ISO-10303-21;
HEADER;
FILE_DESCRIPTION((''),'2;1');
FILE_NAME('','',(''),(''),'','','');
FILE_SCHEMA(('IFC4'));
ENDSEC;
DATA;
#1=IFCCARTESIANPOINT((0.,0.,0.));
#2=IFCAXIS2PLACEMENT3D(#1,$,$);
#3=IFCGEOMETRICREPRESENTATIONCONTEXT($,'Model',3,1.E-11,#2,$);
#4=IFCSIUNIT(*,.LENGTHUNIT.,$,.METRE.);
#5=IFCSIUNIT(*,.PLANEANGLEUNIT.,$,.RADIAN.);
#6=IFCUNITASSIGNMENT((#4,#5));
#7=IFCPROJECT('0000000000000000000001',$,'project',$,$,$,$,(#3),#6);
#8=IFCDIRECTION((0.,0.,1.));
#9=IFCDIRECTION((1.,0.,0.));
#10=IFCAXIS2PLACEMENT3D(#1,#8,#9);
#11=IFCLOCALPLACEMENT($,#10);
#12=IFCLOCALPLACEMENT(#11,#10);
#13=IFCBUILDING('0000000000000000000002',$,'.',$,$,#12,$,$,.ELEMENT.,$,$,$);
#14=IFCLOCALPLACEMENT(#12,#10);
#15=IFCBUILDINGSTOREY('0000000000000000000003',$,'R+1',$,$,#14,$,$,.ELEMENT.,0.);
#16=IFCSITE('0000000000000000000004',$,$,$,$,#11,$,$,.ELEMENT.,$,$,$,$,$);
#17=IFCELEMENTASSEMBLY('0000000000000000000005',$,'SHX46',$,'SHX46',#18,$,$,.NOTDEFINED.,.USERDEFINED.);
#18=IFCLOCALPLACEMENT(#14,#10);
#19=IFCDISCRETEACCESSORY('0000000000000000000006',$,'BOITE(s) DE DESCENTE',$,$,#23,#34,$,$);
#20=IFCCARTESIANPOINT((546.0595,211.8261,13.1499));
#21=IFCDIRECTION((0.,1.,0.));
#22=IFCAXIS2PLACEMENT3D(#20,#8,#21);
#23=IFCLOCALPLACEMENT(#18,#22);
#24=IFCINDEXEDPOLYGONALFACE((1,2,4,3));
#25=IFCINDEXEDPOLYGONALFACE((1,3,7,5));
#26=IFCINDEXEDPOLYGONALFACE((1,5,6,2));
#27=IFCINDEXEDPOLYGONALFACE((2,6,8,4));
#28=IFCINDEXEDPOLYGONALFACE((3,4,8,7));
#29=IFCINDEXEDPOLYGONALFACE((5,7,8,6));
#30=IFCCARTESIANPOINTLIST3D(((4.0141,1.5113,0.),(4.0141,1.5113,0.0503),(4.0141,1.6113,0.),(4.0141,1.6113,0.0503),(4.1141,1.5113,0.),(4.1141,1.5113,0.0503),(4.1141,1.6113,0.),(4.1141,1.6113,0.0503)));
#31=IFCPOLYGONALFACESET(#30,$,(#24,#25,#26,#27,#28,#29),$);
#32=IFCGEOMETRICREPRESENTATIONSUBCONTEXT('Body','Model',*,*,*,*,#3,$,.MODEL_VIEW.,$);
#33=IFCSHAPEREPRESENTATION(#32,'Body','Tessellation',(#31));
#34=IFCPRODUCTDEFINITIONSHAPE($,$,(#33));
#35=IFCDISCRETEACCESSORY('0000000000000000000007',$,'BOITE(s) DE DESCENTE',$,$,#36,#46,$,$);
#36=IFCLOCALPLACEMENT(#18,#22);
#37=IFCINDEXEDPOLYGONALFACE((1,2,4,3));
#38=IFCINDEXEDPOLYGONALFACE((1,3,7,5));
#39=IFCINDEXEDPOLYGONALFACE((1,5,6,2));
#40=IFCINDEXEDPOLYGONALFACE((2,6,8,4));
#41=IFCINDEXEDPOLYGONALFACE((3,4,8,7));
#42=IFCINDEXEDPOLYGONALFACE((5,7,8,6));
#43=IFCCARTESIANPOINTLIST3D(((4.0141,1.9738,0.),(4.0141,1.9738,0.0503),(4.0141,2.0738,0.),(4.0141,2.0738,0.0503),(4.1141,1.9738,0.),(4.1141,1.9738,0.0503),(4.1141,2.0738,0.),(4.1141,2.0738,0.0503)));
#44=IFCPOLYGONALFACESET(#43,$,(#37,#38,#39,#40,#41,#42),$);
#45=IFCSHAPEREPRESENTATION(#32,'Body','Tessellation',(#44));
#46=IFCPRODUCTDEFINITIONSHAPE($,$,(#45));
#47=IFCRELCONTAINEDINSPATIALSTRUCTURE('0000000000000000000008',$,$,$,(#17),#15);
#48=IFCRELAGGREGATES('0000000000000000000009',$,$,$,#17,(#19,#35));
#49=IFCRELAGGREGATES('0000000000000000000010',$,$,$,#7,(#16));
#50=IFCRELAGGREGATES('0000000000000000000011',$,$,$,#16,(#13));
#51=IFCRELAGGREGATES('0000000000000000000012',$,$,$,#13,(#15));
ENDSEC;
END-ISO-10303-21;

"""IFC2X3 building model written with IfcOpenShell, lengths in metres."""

from ifc_helpers import new_model, si_unit, frame, origin, origin_with_axes, place, context, subcontext, project, spatial, polyline, outline, extrude, element, aggregate, save


model = new_model("IFC2X3")

# Units and contexts
model_context = context("Model", 3, precision=1e-11, world=origin())
body_context = subcontext(model_context, "Body", "Model", "MODEL_VIEW")
ifc_project = project(units=[si_unit("LENGTHUNIT", "METRE"), si_unit("PLANEANGLEUNIT", "RADIAN")], contexts=[model_context])

# Site, building, storey
site_placement = place(None, origin_with_axes())
site = spatial("IfcSite", under=ifc_project, at=site_placement, CompositionType="ELEMENT")
building_placement = place(site_placement, origin_with_axes())
building = spatial("IfcBuilding", under=site, at=building_placement, Name=".", CompositionType="ELEMENT")
storey_placement = place(building_placement, origin_with_axes())
storey = spatial("IfcBuildingStorey", under=building, at=storey_placement, Name="R+1", CompositionType="ELEMENT", Elevation=0.0)

# Element assembly, discrete accessories
assembly_1_placement = place(storey_placement, origin_with_axes())
assembly_1 = element("IfcElementAssembly", 1, at=assembly_1_placement, inside=storey, Name="SHX46", ObjectType="SHX46", AssemblyPlace="NOTDEFINED", PredefinedType="USERDEFINED")
discrete_accessory_1_placement = place(assembly_1_placement, frame((546.0595, 211.8261, 13.1499), z_axis=(0.0, 0.0, 1.0), x_axis=(0.0, 1.0, 0.0)))
discrete_accessory_1 = element("IfcDiscreteAccessory", 2, at=discrete_accessory_1_placement, Name="BOITE(s) DE DESCENTE", context=body_context, shape_type="SweptSolid", body=[
    extrude(outline(polyline([(1.5113, -4.0141), (1.5113, -4.1141), (1.6113, -4.1141), (1.6113, -4.0141), (1.5113, -4.0141)])), frame((0.0, 0.0, 0.0), z_axis=(0.0, 0.0, 1.0), x_axis=(0.0, 1.0, 0.0)), (0.0, 0.0, 1.0), 0.0503),
])
discrete_accessory_2_placement = place(assembly_1_placement, frame((546.0595, 211.8261, 13.1499), z_axis=(0.0, 0.0, 1.0), x_axis=(0.0, 1.0, 0.0)))
discrete_accessory_2 = element("IfcDiscreteAccessory", 3, at=discrete_accessory_2_placement, Name="BOITE(s) DE DESCENTE", context=body_context, shape_type="SweptSolid", body=[
    extrude(outline(polyline([(1.9738, -4.0141), (1.9738, -4.1141), (2.0738, -4.1141), (2.0738, -4.0141), (1.9738, -4.0141)])), frame((0.0, 0.0, 0.0), z_axis=(0.0, 0.0, 1.0), x_axis=(0.0, 1.0, 0.0)), (0.0, 0.0, 1.0), 0.0503),
])
aggregate(assembly_1, [discrete_accessory_1, discrete_accessory_2])

save(model, "model.ifc")
